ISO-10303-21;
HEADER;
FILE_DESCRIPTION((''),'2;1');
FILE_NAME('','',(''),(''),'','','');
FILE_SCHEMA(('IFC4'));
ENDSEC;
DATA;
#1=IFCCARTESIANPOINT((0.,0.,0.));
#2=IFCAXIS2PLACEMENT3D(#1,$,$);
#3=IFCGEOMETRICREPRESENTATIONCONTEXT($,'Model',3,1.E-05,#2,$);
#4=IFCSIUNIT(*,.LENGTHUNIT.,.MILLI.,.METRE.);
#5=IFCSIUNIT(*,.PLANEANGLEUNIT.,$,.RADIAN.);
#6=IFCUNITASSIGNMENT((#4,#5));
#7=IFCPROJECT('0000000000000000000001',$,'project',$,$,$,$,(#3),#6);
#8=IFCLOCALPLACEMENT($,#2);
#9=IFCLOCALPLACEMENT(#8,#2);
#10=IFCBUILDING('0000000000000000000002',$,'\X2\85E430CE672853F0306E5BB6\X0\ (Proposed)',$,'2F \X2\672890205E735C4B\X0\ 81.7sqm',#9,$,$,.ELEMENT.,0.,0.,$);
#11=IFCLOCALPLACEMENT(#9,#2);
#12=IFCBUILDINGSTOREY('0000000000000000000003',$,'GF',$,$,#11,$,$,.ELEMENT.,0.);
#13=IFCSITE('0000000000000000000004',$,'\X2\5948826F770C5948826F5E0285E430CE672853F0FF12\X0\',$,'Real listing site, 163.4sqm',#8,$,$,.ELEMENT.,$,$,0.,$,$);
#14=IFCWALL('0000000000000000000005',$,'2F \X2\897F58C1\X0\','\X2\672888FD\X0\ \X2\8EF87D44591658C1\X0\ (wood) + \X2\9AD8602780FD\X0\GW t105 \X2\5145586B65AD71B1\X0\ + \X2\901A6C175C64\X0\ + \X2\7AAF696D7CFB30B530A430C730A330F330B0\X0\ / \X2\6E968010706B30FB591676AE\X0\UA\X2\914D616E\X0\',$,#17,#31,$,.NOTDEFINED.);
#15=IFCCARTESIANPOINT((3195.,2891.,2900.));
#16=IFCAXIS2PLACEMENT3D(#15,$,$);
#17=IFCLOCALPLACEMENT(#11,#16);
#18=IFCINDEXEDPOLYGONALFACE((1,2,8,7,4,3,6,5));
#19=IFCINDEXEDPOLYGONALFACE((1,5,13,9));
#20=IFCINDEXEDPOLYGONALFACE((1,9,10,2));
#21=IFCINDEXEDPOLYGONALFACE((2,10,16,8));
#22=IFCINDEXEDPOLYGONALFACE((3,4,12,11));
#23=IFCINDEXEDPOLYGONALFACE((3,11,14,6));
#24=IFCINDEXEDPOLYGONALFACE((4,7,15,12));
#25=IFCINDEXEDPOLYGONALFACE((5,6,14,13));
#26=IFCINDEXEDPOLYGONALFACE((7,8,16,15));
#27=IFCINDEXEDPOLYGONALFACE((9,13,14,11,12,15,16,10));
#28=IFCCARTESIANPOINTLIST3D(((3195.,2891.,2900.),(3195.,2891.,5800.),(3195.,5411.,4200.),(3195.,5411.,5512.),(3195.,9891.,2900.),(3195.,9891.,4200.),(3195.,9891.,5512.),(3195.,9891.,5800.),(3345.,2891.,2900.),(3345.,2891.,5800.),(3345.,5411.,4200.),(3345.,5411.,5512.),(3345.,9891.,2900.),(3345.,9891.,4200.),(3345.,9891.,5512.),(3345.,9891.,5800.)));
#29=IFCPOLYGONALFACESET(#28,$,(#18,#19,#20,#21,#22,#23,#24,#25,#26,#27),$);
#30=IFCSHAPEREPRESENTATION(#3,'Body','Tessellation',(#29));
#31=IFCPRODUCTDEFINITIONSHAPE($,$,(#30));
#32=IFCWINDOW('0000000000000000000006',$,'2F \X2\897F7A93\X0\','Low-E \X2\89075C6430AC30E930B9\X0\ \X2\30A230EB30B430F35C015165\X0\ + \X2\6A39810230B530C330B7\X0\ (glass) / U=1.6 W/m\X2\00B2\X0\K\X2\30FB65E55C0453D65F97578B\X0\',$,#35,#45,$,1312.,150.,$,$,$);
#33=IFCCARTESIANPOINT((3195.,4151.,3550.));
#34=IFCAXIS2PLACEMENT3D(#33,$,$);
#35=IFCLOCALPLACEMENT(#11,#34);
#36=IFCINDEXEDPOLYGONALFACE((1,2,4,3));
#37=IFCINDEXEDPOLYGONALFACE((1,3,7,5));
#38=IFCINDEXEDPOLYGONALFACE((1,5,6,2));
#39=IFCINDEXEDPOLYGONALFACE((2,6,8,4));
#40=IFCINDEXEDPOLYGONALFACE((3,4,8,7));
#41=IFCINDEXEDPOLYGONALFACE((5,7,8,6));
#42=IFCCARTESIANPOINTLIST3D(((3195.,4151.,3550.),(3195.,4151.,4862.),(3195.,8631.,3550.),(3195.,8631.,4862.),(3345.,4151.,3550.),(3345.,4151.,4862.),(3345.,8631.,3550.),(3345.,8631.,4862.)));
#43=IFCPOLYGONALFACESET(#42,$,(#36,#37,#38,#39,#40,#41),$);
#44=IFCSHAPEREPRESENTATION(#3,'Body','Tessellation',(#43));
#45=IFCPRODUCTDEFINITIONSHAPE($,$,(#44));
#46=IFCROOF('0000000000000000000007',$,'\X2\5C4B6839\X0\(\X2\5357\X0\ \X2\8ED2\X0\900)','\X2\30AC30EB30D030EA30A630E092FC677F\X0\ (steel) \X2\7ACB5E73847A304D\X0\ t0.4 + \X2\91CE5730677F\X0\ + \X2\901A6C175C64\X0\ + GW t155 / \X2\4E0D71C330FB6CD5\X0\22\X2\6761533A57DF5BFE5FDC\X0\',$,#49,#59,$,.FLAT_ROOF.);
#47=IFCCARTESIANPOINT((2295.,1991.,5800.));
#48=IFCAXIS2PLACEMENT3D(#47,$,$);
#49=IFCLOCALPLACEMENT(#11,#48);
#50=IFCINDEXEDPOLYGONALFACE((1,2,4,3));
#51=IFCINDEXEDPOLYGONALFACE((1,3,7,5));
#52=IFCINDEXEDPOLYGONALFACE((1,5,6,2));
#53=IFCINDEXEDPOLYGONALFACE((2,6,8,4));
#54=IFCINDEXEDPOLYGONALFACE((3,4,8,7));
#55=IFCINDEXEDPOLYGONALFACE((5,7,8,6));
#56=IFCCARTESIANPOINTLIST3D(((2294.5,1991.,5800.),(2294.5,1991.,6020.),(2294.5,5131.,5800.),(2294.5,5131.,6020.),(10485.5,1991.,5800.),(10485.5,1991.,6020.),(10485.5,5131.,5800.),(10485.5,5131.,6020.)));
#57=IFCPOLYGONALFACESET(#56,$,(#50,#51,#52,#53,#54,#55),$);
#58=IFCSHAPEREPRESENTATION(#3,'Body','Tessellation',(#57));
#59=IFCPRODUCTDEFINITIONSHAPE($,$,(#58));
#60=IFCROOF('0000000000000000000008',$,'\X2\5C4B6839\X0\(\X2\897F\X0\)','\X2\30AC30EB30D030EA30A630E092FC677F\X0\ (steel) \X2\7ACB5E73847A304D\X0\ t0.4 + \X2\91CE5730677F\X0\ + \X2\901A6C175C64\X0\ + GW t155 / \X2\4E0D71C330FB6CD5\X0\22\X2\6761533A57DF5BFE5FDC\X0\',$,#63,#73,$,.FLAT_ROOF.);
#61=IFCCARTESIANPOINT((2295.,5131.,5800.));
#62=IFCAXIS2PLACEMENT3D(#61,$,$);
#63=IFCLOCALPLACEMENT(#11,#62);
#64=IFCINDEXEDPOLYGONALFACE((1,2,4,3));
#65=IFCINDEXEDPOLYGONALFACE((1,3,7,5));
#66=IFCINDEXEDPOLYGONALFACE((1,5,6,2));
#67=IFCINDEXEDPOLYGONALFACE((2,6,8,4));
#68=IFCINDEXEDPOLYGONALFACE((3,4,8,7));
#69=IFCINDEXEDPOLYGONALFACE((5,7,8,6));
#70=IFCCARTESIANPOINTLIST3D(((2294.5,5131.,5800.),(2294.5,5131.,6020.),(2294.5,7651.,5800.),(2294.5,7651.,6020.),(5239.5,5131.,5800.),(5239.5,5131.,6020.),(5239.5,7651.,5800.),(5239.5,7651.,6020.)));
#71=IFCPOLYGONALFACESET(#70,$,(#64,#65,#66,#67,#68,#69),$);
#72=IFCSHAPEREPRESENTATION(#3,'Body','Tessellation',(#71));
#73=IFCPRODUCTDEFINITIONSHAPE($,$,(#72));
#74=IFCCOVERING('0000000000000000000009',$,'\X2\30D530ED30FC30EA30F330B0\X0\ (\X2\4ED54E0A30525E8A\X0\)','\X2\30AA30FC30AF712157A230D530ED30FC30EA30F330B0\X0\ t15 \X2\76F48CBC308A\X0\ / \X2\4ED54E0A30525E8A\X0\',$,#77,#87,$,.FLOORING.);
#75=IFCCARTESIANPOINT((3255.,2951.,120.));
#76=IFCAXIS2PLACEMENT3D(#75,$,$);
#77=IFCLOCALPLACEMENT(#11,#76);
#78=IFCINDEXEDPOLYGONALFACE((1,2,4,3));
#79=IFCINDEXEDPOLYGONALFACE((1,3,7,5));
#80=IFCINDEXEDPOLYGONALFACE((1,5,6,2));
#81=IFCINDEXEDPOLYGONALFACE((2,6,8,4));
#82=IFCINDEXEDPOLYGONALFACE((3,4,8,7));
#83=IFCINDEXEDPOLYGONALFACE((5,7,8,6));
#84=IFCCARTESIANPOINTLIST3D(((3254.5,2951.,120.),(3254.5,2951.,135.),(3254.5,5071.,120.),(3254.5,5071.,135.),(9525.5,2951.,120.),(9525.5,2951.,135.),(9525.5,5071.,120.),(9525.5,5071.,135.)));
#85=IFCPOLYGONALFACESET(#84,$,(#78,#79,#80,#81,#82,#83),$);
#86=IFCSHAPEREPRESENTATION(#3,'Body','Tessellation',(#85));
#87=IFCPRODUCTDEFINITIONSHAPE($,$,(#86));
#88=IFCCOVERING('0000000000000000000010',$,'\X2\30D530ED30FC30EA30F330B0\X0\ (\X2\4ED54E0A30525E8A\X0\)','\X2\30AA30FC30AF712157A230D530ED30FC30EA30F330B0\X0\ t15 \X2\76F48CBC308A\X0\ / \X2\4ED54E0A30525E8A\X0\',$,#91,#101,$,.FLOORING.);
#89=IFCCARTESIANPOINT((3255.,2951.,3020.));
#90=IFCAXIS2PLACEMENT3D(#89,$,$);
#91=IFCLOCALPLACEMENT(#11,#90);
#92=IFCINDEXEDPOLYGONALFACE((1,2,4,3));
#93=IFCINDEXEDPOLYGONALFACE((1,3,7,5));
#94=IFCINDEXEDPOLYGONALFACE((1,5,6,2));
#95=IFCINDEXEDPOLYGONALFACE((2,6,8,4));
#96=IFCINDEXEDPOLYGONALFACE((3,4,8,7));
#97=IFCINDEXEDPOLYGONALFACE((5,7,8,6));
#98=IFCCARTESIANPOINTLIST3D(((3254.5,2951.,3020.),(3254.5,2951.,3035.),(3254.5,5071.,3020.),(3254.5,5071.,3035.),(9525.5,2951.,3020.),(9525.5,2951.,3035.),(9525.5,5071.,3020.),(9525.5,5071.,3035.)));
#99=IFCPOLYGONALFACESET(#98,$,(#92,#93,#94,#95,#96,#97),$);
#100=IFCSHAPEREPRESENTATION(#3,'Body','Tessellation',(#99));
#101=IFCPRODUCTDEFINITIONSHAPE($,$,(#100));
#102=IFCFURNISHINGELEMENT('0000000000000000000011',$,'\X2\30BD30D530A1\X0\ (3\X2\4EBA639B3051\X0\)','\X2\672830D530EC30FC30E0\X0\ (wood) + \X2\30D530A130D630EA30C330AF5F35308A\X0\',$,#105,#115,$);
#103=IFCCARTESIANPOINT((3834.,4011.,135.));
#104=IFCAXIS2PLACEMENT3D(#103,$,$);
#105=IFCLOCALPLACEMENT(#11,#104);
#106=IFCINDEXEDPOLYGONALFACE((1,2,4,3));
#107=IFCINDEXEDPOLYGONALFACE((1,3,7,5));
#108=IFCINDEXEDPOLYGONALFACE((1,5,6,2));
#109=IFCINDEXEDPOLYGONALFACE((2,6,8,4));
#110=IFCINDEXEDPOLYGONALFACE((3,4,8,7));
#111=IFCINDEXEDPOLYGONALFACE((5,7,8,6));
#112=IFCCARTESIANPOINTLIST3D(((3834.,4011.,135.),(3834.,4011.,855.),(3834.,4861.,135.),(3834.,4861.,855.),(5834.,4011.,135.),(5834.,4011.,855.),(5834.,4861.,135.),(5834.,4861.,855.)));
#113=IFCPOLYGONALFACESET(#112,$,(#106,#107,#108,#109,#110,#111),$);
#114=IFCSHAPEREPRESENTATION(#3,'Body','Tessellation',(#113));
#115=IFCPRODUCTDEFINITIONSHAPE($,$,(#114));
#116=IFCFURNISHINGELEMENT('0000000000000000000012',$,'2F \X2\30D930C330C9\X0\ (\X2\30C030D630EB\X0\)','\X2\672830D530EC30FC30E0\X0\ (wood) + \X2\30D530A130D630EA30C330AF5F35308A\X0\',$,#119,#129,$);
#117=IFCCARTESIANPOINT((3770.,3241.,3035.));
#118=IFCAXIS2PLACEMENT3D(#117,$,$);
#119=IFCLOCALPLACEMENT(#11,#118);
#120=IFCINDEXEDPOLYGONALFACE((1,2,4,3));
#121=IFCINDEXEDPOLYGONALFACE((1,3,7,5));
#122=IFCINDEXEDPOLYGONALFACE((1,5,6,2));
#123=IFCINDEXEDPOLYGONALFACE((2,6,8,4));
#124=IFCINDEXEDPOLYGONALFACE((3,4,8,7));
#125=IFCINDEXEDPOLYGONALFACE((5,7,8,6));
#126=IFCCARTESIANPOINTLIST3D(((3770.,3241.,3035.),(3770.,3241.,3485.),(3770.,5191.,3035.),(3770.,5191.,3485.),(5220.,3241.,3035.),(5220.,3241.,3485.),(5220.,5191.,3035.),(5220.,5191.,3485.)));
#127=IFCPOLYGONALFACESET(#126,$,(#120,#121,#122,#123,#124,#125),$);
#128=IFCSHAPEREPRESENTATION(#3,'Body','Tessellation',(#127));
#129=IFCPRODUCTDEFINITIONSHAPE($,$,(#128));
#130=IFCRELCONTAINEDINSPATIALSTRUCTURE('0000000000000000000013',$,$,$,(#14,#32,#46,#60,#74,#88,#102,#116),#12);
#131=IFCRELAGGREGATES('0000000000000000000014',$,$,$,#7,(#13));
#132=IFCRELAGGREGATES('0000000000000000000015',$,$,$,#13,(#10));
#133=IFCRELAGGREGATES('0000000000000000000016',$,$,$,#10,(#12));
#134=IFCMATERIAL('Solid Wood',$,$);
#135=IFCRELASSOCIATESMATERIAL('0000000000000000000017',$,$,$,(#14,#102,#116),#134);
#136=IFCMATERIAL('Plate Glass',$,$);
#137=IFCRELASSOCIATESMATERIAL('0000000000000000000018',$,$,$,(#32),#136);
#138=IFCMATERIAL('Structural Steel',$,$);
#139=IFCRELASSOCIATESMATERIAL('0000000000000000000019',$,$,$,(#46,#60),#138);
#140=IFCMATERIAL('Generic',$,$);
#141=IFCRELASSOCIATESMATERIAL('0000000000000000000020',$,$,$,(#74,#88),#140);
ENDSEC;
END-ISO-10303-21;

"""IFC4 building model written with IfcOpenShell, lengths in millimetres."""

from ifc_helpers import new_model, si_unit, frame, frame_2d, origin, place, context, project, spatial, rectangle, extrude, material, element, fill, save


model = new_model("IFC4")

# Units and contexts
model_context = context("Model", 3, precision=1e-05, world=origin())
ifc_project = project(units=[si_unit("LENGTHUNIT", "METRE", prefix="MILLI"), si_unit("PLANEANGLEUNIT", "RADIAN")], contexts=[model_context])

# Site, building, storey
site_placement = place(None, origin())
site = spatial("IfcSite", under=ifc_project, at=site_placement, Name="奈良県奈良市藤ノ木台２", ObjectType="Real listing site, 163.4sqm", CompositionType="ELEMENT", RefElevation=0.0)
building_placement = place(site_placement, origin())
building = spatial("IfcBuilding", under=site, at=building_placement, Name="藤ノ木台の家 (Proposed)", ObjectType="2F 木造平屋 81.7sqm", CompositionType="ELEMENT", ElevationOfRefHeight=0.0, ElevationOfTerrain=0.0)
storey_placement = place(building_placement, origin())
storey = spatial("IfcBuildingStorey", under=building, at=storey_placement, Name="GF", CompositionType="ELEMENT", Elevation=0.0)

# Shared definitions
ifc_material_1 = material(Name="Solid Wood")

# Shared definitions
ifc_material_2 = material(Name="Plate Glass")

# Wall, opening, window
wall_1_placement = place(storey_placement, frame((3195.0, 2891.0, 2900.0)))
wall_1 = element("IfcWall", 1, at=wall_1_placement, inside=storey, material=ifc_material_1, Name="2F 西壁", Description="木製 軸組外壁 (wood) + 高性能GW t105 充填断熱 + 通気層 + 窯業系サイディング / 準耐火・外皮UA配慮", PredefinedType="NOTDEFINED", context=model_context, shape_type="SweptSolid", body=[
    extrude(rectangle(XDim=150.0, YDim=7000.0, at=frame_2d((75.0, 3500.0))), frame((3195.0, 2891.0, 2900.0)), (0.0, 0.0, 1.0), 2900.0),
])
opening_1_placement = place(storey_placement, frame((3195.0, 4151.0, 3550.0)))
opening_1 = element("IfcOpeningElement", 2, at=opening_1_placement, cuts=wall_1, PredefinedType="NOTDEFINED", context=model_context, shape_type="SweptSolid", body=[
    extrude(rectangle(XDim=150.0, YDim=4480.0, at=frame_2d((75.0, 2240.0))), frame((3195.0, 4151.0, 3550.0)), (0.0, 0.0, 1.0), 1312.0),
])
window_1_placement = place(storey_placement, frame((3195.0, 4151.0, 3550.0)))
window_1 = element("IfcWindow", 3, at=window_1_placement, inside=storey, material=ifc_material_2, Name="2F 西窓", Description="Low-E 複層ガラス アルゴン封入 + 樹脂サッシ (glass) / U=1.6 W/m²K・日射取得型", OverallHeight=1312.0, OverallWidth=150.0, context=model_context, shape_type="SweptSolid", body=[
    extrude(rectangle(XDim=150.0, YDim=4480.0, at=frame_2d((75.0, 2240.0))), frame((3195.0, 4151.0, 3550.0)), (0.0, 0.0, 1.0), 1312.0),
])
fill(opening_1, window_1)

# Roofs
ifc_material_3 = material(Name="Structural Steel")
roof_1_placement = place(storey_placement, frame((2295.0, 1991.0, 5800.0)))
element("IfcRoof", 4, at=roof_1_placement, inside=storey, material=ifc_material_3, Name="屋根(南 軒900)", Description="ガルバリウム鋼板 (steel) 立平葺き t0.4 + 野地板 + 通気層 + GW t155 / 不燃・法22条区域対応", PredefinedType="FLAT_ROOF", context=model_context, shape_type="SweptSolid", body=[
    extrude(rectangle(XDim=8191.0, YDim=3140.0, at=frame_2d((4095.0, 1570.0))), frame((2295.0, 1991.0, 5800.0)), (0.0, 0.0, 1.0), 220.0),
])
roof_2_placement = place(storey_placement, frame((2295.0, 5131.0, 5800.0)))
element("IfcRoof", 5, at=roof_2_placement, inside=storey, material=ifc_material_3, Name="屋根(西)", Description="ガルバリウム鋼板 (steel) 立平葺き t0.4 + 野地板 + 通気層 + GW t155 / 不燃・法22条区域対応", PredefinedType="FLAT_ROOF", context=model_context, shape_type="SweptSolid", body=[
    extrude(rectangle(XDim=2945.0, YDim=2520.0, at=frame_2d((1472.0, 1260.0))), frame((2295.0, 5131.0, 5800.0)), (0.0, 0.0, 1.0), 220.0),
])

# Coverings
ifc_material_4 = material(Name="Generic")
covering_1_placement = place(storey_placement, frame((3255.0, 2951.0, 120.0)))
element("IfcCovering", 6, at=covering_1_placement, inside=storey, material=ifc_material_4, Name="フローリング (仕上げ床)", Description="オーク無垢フローリング t15 直貼り / 仕上げ床", PredefinedType="FLOORING", context=model_context, shape_type="SweptSolid", body=[
    extrude(rectangle(XDim=6271.0, YDim=2120.0, at=frame_2d((3135.0, 1060.0))), frame((3255.0, 2951.0, 120.0)), (0.0, 0.0, 1.0), 15.0),
])
covering_2_placement = place(storey_placement, frame((3255.0, 2951.0, 3020.0)))
element("IfcCovering", 7, at=covering_2_placement, inside=storey, material=ifc_material_4, Name="フローリング (仕上げ床)", Description="オーク無垢フローリング t15 直貼り / 仕上げ床", PredefinedType="FLOORING", context=model_context, shape_type="SweptSolid", body=[
    extrude(rectangle(XDim=6271.0, YDim=2120.0, at=frame_2d((3135.0, 1060.0))), frame((3255.0, 2951.0, 3020.0)), (0.0, 0.0, 1.0), 15.0),
])

# Furnishing elements
furnishing_1_placement = place(storey_placement, frame((3834.0, 4011.0, 135.0)))
element("IfcFurnishingElement", 8, at=furnishing_1_placement, inside=storey, material=ifc_material_1, Name="ソファ (3人掛け)", Description="木フレーム (wood) + ファブリック張り", context=model_context, shape_type="SweptSolid", body=[
    extrude(rectangle(XDim=2000.0, YDim=850.0, at=frame_2d((1000.0, 425.0))), frame((3834.0, 4011.0, 135.0)), (0.0, 0.0, 1.0), 720.0),
])
furnishing_2_placement = place(storey_placement, frame((3770.0, 3241.0, 3035.0)))
element("IfcFurnishingElement", 9, at=furnishing_2_placement, inside=storey, material=ifc_material_1, Name="2F ベッド (ダブル)", Description="木フレーム (wood) + ファブリック張り", context=model_context, shape_type="SweptSolid", body=[
    extrude(rectangle(XDim=1450.0, YDim=1950.0, at=frame_2d((725.0, 975.0))), frame((3770.0, 3241.0, 3035.0)), (0.0, 0.0, 1.0), 450.0),
])

save(model, "model.ifc")
